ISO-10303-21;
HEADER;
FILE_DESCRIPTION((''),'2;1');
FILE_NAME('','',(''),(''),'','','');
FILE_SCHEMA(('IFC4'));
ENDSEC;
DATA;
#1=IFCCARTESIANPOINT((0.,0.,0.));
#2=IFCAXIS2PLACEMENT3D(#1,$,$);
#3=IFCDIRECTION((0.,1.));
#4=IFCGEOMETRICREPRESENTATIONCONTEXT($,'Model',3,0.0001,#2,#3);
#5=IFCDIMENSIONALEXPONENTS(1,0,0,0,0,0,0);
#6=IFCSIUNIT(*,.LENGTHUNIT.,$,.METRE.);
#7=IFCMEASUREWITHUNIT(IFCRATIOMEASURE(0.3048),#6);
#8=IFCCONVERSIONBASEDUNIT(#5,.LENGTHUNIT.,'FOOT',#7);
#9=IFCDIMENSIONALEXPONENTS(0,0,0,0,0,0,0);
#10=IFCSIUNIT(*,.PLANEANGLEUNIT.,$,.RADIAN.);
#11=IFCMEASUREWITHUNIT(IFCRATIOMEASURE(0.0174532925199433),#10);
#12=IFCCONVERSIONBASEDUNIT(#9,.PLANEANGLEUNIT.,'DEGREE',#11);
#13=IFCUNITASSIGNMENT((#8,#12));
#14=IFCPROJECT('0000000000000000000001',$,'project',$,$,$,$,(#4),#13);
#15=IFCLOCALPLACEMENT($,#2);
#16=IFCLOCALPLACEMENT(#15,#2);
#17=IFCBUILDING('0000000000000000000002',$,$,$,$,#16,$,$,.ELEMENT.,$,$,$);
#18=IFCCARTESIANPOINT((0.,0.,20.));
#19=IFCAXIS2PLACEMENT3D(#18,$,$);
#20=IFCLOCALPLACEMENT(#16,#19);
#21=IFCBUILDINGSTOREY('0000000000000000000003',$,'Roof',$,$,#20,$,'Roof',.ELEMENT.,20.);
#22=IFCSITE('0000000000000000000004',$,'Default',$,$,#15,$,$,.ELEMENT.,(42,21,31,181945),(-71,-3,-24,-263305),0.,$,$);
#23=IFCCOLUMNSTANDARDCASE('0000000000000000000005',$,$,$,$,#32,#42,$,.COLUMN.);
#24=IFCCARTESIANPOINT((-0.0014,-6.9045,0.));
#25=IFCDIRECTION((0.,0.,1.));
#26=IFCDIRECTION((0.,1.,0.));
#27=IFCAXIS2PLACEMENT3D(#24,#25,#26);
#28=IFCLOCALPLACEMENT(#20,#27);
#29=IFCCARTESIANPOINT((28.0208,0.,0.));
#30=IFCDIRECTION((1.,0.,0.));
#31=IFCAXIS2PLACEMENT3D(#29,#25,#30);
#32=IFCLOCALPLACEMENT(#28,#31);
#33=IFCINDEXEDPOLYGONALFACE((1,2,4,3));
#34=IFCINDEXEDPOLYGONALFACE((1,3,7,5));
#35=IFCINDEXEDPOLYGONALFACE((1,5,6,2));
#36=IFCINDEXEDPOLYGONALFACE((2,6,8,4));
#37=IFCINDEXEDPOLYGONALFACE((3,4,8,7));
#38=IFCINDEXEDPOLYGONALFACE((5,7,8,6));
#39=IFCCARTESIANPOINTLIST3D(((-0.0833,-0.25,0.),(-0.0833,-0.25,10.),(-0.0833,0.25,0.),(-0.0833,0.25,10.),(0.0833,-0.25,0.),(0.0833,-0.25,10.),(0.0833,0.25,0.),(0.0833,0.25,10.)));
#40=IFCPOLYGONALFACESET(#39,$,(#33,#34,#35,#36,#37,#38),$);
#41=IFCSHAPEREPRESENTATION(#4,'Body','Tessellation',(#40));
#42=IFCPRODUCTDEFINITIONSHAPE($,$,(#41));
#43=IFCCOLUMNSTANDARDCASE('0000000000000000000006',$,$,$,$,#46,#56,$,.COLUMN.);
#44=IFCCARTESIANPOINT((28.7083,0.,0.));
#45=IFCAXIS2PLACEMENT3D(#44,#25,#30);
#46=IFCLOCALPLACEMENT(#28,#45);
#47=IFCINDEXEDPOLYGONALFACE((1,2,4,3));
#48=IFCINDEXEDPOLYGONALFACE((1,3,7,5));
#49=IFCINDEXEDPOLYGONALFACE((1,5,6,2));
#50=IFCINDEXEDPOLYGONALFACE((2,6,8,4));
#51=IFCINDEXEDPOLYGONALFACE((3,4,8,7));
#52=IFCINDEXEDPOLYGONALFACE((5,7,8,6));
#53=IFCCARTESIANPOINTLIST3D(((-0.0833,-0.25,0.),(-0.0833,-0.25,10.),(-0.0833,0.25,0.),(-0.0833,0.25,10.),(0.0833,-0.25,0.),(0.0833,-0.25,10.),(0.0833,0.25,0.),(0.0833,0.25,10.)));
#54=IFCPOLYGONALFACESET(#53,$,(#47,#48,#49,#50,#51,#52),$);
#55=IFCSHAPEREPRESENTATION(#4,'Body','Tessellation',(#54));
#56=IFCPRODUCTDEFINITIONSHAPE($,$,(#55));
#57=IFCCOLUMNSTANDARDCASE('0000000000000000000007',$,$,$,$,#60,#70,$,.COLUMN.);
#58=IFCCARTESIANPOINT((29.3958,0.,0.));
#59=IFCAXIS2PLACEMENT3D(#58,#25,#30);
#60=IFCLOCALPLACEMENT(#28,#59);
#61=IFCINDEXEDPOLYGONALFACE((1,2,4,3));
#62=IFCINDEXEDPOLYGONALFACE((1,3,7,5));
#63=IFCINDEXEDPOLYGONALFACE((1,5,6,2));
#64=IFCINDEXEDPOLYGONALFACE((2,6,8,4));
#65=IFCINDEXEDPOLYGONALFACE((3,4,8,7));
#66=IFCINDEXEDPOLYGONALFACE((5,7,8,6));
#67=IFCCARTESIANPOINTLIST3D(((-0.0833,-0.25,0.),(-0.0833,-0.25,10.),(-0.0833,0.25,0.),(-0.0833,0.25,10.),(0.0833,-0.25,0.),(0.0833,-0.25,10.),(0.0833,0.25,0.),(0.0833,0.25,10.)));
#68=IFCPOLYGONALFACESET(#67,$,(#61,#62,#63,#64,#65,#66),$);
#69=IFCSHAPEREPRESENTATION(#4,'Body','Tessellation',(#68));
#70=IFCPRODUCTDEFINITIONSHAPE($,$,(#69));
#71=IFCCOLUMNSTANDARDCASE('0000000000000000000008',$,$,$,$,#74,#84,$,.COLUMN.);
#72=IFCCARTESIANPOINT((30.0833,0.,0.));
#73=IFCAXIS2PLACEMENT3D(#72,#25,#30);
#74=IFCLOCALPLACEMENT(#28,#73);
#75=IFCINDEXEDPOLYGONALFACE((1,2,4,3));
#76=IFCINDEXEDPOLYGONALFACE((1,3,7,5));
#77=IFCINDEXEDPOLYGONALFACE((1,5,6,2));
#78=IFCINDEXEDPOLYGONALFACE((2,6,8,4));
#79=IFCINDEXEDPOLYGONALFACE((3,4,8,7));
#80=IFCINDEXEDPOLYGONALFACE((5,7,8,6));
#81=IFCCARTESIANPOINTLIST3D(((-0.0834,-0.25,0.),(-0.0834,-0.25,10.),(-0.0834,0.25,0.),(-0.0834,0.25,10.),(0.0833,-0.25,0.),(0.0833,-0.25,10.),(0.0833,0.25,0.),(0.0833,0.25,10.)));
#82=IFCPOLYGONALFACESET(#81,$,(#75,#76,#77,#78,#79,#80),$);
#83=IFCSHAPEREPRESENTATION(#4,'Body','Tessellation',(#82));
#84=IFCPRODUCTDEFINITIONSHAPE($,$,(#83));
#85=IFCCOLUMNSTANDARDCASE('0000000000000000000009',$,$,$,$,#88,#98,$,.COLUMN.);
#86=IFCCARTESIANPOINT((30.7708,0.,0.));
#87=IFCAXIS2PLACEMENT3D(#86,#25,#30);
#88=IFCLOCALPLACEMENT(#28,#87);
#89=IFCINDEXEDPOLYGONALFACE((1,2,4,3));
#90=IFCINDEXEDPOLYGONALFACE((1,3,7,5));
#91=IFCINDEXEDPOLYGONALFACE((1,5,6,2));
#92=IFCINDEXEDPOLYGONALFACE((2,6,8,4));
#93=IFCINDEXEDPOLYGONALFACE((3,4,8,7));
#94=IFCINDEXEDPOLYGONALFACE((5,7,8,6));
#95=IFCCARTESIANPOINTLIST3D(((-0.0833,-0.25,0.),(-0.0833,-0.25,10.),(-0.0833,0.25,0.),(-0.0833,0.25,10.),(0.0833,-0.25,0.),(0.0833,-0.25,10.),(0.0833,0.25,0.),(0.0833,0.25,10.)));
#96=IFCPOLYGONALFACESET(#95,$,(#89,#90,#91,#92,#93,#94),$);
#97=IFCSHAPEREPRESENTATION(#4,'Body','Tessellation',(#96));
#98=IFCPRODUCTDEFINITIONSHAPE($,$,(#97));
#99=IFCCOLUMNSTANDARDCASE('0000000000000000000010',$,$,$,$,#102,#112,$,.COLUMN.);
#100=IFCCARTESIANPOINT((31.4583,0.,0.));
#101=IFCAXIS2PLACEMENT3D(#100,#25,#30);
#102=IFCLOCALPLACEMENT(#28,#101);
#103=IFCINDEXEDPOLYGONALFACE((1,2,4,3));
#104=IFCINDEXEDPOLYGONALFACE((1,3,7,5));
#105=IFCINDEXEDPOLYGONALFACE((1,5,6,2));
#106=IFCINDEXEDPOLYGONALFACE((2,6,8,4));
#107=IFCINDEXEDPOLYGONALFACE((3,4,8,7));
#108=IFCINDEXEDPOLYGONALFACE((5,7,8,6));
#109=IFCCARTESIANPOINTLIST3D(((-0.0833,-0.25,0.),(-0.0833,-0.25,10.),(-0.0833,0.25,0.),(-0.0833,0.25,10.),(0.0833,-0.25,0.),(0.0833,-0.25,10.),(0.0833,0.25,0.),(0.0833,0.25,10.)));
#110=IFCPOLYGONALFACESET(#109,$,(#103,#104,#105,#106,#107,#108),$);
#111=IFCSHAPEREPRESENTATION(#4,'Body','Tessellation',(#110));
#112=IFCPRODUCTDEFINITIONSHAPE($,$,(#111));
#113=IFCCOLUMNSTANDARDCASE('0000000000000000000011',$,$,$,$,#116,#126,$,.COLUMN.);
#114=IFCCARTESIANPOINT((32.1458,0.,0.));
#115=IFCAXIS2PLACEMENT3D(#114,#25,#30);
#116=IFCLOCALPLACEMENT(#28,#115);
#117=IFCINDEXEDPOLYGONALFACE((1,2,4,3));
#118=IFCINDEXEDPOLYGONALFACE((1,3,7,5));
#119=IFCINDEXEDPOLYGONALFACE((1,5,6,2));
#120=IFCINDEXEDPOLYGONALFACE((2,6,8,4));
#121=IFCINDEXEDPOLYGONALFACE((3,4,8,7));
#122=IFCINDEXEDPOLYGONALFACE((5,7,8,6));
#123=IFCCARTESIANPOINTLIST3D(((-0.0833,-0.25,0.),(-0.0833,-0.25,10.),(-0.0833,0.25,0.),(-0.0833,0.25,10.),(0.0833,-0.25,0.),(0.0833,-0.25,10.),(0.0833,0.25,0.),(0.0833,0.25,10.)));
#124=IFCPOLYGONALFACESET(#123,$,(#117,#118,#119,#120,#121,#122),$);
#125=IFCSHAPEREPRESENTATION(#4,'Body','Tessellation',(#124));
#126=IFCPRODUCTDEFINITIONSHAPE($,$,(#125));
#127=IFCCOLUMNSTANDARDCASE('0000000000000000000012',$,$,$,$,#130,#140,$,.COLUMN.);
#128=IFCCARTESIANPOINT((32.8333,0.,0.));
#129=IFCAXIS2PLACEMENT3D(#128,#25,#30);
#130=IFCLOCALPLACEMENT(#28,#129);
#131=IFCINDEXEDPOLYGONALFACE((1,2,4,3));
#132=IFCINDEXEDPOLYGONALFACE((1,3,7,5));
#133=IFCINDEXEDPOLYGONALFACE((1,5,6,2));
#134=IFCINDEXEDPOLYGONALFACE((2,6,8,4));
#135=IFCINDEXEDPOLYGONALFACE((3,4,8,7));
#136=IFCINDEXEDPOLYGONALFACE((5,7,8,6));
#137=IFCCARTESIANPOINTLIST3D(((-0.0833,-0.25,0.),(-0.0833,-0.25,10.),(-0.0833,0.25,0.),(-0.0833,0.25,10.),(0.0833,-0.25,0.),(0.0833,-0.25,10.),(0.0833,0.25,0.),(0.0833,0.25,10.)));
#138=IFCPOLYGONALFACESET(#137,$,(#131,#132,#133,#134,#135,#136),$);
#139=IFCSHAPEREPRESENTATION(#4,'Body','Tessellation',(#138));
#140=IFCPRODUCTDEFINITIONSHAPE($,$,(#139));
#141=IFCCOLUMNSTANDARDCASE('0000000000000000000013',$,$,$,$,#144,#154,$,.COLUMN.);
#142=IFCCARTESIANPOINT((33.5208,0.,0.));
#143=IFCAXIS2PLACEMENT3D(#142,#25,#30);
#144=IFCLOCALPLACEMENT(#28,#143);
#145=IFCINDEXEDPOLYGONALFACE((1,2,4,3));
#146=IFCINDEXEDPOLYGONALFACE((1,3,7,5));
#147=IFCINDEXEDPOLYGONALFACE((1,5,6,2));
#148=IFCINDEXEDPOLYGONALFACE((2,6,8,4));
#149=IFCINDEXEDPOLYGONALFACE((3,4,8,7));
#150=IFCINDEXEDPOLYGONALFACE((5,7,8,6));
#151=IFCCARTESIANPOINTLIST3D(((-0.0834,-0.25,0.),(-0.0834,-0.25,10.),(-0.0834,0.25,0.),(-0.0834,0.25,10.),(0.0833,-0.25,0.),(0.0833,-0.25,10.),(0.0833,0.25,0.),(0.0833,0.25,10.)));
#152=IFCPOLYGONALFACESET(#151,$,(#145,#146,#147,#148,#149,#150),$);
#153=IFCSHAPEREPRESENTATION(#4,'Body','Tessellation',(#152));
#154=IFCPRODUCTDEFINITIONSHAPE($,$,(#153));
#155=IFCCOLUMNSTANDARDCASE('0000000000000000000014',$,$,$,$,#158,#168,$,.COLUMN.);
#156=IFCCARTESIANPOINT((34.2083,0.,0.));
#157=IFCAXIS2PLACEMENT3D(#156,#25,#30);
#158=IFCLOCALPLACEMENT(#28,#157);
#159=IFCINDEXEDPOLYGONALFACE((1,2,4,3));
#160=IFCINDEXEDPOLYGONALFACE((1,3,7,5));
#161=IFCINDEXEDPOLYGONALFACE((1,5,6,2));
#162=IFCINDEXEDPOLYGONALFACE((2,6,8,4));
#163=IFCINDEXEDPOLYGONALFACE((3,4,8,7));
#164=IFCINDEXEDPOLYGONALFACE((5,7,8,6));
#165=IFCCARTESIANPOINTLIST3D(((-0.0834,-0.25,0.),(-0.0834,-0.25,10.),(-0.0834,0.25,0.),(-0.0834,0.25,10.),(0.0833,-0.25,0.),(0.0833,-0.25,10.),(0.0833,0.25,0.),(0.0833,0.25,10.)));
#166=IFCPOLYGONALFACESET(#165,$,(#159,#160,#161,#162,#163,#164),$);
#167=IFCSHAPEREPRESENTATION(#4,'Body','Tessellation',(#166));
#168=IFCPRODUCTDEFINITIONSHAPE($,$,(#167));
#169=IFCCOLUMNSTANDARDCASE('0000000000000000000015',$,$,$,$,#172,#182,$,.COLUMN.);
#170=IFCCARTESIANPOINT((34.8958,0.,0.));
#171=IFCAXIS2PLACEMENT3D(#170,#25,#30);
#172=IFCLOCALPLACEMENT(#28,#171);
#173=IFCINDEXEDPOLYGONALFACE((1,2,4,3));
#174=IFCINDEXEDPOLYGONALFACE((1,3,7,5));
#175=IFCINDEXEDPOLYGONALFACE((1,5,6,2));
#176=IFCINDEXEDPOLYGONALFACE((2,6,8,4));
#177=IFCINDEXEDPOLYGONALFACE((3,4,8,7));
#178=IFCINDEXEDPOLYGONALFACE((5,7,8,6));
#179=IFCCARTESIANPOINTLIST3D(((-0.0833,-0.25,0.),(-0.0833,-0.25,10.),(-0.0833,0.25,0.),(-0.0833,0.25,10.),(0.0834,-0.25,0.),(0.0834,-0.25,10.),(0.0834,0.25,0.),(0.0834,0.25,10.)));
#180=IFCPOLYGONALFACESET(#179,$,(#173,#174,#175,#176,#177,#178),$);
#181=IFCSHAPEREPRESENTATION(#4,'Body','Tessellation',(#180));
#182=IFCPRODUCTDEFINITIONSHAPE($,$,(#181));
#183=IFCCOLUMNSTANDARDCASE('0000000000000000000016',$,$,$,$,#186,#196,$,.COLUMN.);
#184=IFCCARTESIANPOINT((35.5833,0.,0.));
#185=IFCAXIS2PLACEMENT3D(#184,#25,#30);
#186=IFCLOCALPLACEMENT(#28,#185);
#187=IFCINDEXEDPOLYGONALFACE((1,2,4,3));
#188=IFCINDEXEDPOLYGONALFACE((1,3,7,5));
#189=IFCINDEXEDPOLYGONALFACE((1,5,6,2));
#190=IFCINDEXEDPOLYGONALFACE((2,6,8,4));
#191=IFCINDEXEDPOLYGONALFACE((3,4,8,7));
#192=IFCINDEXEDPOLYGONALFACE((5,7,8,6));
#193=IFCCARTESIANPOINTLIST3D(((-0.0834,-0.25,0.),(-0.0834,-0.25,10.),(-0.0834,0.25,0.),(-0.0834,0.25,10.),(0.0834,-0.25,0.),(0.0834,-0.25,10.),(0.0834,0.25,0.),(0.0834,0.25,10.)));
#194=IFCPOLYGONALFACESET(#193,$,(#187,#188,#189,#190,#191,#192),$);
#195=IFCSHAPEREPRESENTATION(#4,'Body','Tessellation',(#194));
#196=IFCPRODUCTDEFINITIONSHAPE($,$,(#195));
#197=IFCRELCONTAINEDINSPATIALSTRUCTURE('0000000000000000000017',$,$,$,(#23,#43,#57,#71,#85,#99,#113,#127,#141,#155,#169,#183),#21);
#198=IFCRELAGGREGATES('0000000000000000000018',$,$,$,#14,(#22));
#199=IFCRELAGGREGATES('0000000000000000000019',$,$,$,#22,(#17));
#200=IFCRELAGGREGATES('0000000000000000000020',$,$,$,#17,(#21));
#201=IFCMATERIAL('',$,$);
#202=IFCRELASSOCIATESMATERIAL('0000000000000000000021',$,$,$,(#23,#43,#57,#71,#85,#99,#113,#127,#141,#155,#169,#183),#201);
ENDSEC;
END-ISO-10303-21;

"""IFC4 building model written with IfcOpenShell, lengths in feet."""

from ifc_helpers import new_model, entity, si_unit, converted_unit, direction, frame, origin, place, context, project, spatial, rectangle, extrude, material, element, save


model = new_model("IFC4")

# Units and contexts
model_context = context("Model", 3, precision=0.0001, world=origin(), true_north=direction((0.0, 1.0)))
ifc_project = project(units=[converted_unit("LENGTHUNIT", "FOOT", entity("IfcRatioMeasure", 0.3048), si_unit("LENGTHUNIT", "METRE"), dimensions=[1, 0, 0, 0, 0, 0, 0]), converted_unit("PLANEANGLEUNIT", "DEGREE", entity("IfcRatioMeasure", 0.0174532925199433), si_unit("PLANEANGLEUNIT", "RADIAN"), dimensions=[0, 0, 0, 0, 0, 0, 0])], contexts=[model_context])

# Site, building, storey
site_placement = place(None, origin())
site = spatial("IfcSite", under=ifc_project, at=site_placement, Name="Default", CompositionType="ELEMENT", RefLatitude=(42, 21, 31, 181945), RefLongitude=(-71, -3, -24, -263305), RefElevation=0.0)
building_placement = place(site_placement, origin())
building = spatial("IfcBuilding", under=site, at=building_placement, CompositionType="ELEMENT")
storey_placement = place(building_placement, frame((0.0, 0.0, 20.0)))
storey = spatial("IfcBuildingStorey", under=building, at=storey_placement, Name="Roof", LongName="Roof", CompositionType="ELEMENT", Elevation=20.0)

# Columns
ifc_material_1 = material(Name="")
placement = place(storey_placement, frame((-0.0014, -6.9045, 0.0), z_axis=(0.0, 0.0, 1.0), x_axis=(0.0, 1.0, 0.0)))
for number, where, z_axis, x_axis in (
    (1, (28.0208, 0.0, 0.0), (0.0, 0.0, 1.0), (1.0, 0.0, 0.0)),
    (2, (28.7083, 0.0, 0.0), (0.0, 0.0, 1.0), (1.0, 0.0, 0.0)),
    (3, (29.3958, 0.0, 0.0), (0.0, 0.0, 1.0), (1.0, 0.0, 0.0)),
    (4, (30.0833, 0.0, 0.0), (0.0, 0.0, 1.0), (1.0, 0.0, 0.0)),
    (5, (30.7708, 0.0, 0.0), (0.0, 0.0, 1.0), (1.0, 0.0, 0.0)),
    (6, (31.4583, 0.0, 0.0), (0.0, 0.0, 1.0), (1.0, 0.0, 0.0)),
    (7, (32.1458, 0.0, 0.0), (0.0, 0.0, 1.0), (1.0, 0.0, 0.0)),
    (8, (32.8333, 0.0, 0.0), (0.0, 0.0, 1.0), (1.0, 0.0, 0.0)),
    (9, (33.5208, 0.0, 0.0), (0.0, 0.0, 1.0), (1.0, 0.0, 0.0)),
    (10, (34.2083, 0.0, 0.0), (0.0, 0.0, 1.0), (1.0, 0.0, 0.0)),
    (11, (34.8958, 0.0, 0.0), (0.0, 0.0, 1.0), (1.0, 0.0, 0.0)),
    (12, (35.5833, 0.0, 0.0), (0.0, 0.0, 1.0), (1.0, 0.0, 0.0)),
):
    element("IfcColumnStandardCase", number, at=place(placement, frame(where, z_axis=z_axis, x_axis=x_axis)), inside=storey, material=ifc_material_1, PredefinedType="COLUMN", context=model_context, shape_type="SweptSolid", body=[
        extrude(rectangle(XDim=0.1667, YDim=0.5), origin(), (0.0, 0.0, 1.0), 10.0),
    ])

save(model, "model.ifc")
